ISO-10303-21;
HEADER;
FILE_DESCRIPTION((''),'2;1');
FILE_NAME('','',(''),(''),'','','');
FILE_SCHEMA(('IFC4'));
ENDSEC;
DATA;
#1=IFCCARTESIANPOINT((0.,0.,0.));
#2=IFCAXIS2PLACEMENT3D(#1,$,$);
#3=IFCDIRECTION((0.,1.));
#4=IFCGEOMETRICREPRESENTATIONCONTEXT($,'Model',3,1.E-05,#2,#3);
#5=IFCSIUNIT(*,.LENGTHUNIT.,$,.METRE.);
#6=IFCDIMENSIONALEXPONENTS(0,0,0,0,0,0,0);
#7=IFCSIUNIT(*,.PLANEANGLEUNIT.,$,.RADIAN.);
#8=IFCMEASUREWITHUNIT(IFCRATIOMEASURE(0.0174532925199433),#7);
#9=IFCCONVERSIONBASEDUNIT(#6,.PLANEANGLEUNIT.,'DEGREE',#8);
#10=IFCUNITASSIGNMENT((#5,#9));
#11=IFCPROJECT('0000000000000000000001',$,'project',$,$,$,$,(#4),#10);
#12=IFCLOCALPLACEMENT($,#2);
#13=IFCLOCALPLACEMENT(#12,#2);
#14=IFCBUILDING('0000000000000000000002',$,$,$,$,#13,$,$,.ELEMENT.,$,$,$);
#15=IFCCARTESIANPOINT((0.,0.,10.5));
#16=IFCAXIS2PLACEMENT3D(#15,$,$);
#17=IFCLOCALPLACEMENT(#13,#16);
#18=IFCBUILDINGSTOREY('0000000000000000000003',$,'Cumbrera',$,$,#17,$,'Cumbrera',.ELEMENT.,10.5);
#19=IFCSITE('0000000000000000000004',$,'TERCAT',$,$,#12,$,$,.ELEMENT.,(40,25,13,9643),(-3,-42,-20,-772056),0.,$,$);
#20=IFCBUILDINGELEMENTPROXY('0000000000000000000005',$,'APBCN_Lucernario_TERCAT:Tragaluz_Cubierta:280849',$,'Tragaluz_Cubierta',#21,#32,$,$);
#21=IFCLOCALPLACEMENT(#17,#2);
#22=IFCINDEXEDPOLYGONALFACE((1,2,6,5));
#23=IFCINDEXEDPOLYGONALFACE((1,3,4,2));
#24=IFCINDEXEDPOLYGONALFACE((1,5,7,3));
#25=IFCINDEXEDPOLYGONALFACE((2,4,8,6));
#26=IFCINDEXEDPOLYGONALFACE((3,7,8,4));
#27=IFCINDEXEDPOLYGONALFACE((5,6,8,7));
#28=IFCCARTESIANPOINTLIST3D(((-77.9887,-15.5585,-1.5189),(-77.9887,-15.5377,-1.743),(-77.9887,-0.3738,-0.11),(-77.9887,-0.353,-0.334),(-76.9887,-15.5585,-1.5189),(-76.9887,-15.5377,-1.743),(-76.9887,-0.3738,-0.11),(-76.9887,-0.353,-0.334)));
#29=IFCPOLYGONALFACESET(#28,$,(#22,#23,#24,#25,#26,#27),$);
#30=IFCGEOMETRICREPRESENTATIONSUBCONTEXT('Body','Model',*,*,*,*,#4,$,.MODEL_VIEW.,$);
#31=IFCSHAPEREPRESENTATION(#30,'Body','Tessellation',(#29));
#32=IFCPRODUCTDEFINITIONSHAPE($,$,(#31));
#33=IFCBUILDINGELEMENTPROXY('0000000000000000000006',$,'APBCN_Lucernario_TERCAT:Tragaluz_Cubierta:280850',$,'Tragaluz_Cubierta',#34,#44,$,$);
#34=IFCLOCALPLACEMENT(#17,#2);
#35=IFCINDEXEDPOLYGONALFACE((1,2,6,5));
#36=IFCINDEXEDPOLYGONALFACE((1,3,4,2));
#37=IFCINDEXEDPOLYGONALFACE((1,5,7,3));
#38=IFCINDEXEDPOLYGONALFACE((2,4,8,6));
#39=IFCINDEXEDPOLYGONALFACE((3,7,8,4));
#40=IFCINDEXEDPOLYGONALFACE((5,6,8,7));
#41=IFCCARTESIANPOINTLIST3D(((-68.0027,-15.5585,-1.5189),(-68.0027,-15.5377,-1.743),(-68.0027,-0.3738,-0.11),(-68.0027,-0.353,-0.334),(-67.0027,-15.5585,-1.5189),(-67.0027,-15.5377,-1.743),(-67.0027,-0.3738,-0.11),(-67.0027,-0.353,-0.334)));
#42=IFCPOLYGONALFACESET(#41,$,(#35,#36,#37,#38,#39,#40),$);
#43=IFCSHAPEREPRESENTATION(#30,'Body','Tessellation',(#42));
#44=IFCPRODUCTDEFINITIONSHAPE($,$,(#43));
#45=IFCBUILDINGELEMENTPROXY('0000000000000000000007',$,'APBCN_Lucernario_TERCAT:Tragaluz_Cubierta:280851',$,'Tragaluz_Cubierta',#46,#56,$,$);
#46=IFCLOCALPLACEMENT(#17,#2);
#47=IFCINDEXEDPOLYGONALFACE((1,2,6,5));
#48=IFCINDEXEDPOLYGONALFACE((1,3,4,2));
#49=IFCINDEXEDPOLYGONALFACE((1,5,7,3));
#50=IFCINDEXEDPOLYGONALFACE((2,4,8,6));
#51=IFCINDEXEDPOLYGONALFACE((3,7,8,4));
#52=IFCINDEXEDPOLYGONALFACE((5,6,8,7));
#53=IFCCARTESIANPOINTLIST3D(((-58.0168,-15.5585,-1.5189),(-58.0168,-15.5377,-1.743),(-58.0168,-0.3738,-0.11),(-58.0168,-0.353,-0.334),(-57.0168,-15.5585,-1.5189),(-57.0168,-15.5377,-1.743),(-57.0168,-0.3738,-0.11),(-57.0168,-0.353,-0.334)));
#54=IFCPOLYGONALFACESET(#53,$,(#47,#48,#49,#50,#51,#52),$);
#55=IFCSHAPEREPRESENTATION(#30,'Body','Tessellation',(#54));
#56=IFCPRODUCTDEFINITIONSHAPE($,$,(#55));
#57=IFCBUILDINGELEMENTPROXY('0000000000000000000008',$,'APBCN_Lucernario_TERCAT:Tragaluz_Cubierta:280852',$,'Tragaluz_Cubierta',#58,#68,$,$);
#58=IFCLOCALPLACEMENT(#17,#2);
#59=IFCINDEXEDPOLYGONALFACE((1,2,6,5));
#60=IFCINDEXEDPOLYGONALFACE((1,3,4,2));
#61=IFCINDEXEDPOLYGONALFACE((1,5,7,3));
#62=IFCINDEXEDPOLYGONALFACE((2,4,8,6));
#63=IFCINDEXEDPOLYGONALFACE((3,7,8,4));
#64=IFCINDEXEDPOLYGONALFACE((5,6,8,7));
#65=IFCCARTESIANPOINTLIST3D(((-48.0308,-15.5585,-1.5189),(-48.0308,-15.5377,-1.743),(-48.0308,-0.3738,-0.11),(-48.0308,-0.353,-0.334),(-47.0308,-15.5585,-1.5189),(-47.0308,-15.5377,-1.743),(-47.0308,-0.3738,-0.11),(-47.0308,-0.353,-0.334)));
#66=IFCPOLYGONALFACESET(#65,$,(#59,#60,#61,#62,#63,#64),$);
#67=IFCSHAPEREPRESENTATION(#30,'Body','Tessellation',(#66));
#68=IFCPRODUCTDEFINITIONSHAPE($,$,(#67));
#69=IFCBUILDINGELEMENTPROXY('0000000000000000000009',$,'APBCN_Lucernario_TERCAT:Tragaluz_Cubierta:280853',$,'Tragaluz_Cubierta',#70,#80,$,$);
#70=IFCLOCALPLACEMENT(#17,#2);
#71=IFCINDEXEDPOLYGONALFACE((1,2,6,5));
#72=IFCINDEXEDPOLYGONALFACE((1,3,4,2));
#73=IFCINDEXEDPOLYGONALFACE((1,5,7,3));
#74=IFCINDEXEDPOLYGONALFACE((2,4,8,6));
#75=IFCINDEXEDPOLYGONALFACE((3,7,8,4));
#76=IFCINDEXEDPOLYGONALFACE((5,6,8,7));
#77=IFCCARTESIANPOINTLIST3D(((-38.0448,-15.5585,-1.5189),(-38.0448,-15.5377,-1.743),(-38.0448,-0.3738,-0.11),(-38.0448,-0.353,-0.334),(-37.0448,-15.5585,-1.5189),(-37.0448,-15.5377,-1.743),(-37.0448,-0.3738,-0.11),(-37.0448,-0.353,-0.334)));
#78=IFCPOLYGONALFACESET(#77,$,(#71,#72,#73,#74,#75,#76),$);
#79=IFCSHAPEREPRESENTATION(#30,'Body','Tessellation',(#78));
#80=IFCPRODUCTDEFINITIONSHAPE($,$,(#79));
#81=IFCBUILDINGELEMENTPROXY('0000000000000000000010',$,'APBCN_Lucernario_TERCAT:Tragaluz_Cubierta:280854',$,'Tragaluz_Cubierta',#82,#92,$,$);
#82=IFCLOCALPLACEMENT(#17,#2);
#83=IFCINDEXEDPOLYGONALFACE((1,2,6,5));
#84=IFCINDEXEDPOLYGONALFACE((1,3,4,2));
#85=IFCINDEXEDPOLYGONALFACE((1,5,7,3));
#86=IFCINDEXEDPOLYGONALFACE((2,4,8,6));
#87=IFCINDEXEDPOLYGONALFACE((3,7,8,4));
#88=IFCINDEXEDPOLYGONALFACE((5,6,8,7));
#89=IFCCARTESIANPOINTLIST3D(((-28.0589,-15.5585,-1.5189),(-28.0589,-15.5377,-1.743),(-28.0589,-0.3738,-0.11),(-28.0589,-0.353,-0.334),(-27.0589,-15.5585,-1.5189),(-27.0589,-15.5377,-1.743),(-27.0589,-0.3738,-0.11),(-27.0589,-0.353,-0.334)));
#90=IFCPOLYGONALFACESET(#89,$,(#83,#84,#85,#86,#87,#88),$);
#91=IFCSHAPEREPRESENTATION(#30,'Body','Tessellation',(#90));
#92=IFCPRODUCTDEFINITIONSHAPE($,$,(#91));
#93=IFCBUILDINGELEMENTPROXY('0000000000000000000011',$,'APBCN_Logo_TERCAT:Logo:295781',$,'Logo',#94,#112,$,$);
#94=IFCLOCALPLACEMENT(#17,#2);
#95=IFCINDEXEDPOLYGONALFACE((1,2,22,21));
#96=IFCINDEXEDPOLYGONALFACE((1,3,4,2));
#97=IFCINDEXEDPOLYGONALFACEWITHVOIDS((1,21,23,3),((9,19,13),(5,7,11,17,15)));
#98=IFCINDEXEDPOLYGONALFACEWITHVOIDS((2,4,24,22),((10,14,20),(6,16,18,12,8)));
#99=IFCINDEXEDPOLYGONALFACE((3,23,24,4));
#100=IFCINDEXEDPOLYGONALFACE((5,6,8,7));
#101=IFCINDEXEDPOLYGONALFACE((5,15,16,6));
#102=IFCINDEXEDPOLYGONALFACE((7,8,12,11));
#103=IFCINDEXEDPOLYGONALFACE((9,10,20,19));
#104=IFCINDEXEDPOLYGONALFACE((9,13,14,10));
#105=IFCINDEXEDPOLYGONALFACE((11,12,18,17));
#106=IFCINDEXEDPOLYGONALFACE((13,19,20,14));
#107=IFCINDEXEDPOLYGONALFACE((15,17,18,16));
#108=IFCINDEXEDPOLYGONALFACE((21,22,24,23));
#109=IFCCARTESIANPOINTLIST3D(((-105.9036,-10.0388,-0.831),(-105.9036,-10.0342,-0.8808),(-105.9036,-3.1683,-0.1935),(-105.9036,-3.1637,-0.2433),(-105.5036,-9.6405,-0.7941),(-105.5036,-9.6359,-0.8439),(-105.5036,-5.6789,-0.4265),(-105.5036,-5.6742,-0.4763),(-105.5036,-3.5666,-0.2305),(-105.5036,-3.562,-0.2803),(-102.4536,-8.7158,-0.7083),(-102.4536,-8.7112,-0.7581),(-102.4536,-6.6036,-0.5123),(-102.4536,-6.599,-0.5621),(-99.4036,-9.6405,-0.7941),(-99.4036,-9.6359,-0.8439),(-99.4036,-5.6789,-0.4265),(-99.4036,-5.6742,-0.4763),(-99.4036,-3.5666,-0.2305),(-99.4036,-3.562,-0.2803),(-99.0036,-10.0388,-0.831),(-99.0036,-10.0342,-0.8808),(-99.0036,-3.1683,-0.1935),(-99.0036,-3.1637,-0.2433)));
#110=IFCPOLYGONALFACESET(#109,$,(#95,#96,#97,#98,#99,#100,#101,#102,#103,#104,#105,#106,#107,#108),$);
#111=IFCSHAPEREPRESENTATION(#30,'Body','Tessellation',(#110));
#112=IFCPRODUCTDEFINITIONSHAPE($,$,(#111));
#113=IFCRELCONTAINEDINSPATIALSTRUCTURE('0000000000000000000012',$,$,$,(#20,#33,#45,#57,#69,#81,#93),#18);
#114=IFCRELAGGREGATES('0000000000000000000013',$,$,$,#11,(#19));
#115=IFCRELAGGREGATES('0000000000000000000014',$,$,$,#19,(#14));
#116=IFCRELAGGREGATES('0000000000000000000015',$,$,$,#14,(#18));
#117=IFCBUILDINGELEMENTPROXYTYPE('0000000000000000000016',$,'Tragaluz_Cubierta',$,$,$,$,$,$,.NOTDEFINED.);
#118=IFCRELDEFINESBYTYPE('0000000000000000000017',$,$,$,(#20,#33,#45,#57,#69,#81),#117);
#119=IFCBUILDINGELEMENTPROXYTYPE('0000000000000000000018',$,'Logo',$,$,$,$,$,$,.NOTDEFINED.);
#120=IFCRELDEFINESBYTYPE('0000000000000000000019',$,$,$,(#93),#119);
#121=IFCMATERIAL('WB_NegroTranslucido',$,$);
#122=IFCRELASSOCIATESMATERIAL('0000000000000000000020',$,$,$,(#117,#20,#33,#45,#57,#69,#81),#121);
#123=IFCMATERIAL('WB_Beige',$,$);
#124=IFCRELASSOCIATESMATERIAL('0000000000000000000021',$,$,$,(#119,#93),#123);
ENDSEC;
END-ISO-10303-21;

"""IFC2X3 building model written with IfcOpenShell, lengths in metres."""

from ifc_helpers import new_model, entity, si_unit, converted_unit, direction, frame, origin, origin_2d_with_axis, place, context, subcontext, project, spatial, polyline, rectangle, outline, extrude, source, transform, mapped, material, type_object, type_shapes, element, save


model = new_model("IFC2X3")

# Units and contexts
model_context = context("Model", 3, precision=1e-05, world=origin(), true_north=direction((0.0, 1.0)))
body_context = subcontext(model_context, "Body", "Model", "MODEL_VIEW")
ifc_project = project(units=[si_unit("LENGTHUNIT", "METRE"), converted_unit("PLANEANGLEUNIT", "DEGREE", entity("IfcRatioMeasure", 0.0174532925199433), si_unit("PLANEANGLEUNIT", "RADIAN"), dimensions=[0, 0, 0, 0, 0, 0, 0])], contexts=[model_context])

# Site, building, storey
site_placement = place(None, origin())
site = spatial("IfcSite", under=ifc_project, at=site_placement, Name="TERCAT", CompositionType="ELEMENT", RefLatitude=(40, 25, 13, 9643), RefLongitude=(-3, -42, -20, -772056), RefElevation=0.0)
building_placement = place(site_placement, origin())
building = spatial("IfcBuilding", under=site, at=building_placement, CompositionType="ELEMENT")
storey_placement = place(building_placement, frame((0.0, 0.0, 10.5)))
storey = spatial("IfcBuildingStorey", under=building, at=storey_placement, Name="Cumbrera", LongName="Cumbrera", CompositionType="ELEMENT", Elevation=10.5)

# Building element proxies
ifc_material_1 = material(Name="WB_NegroTranslucido")
building_element_proxy_type_1 = type_object("IfcBuildingElementProxyType", Name="Tragaluz_Cubierta", PredefinedType="NOTDEFINED", material=ifc_material_1)
shared_shape_1 = source(origin(), body_context, "Body", "SweptSolid", [
    extrude(rectangle(XDim=15.25, YDim=1.0, at=origin_2d_with_axis()), frame((0.5, 7.625, 0.0), z_axis=(0.0, 0.0, 1.0), x_axis=(0.0, 1.0, 0.0)), (0.0, 0.0, 1.0), 0.225),
])
type_shapes(building_element_proxy_type_1, [shared_shape_1])
for number, where, z_axis, x_axis, name in (
    (1, (-76.9887, -0.353, -0.334), (0.0, -0.09239, 0.995723), (-1.0, 0.0, 0.0), "APBCN_Lucernario_TERCAT:Tragaluz_Cubierta:280849"),
    (2, (-67.0027, -0.353, -0.334), (0.0, -0.09239, 0.995723), (-1.0, 0.0, 0.0), "APBCN_Lucernario_TERCAT:Tragaluz_Cubierta:280850"),
    (3, (-57.0168, -0.353, -0.334), (0.0, -0.09239, 0.995723), (-1.0, 0.0, 0.0), "APBCN_Lucernario_TERCAT:Tragaluz_Cubierta:280851"),
    (4, (-47.0308, -0.353, -0.334), (0.0, -0.09239, 0.995723), (-1.0, 0.0, 0.0), "APBCN_Lucernario_TERCAT:Tragaluz_Cubierta:280852"),
    (5, (-37.0448, -0.353, -0.334), (0.0, -0.09239, 0.995723), (-1.0, 0.0, 0.0), "APBCN_Lucernario_TERCAT:Tragaluz_Cubierta:280853"),
    (6, (-27.0589, -0.353, -0.334), (0.0, -0.09239, 0.995723), (-1.0, 0.0, 0.0), "APBCN_Lucernario_TERCAT:Tragaluz_Cubierta:280854"),
):
    element("IfcBuildingElementProxy", number, at=place(storey_placement, frame(where, z_axis=z_axis, x_axis=x_axis)), inside=storey, type_object=building_element_proxy_type_1, material=ifc_material_1, Name=name, ObjectType="Tragaluz_Cubierta", context=body_context, shape_type="MappedRepresentation", body=[
        mapped(shared_shape_1, transform((0.0, 0.0, 0.0), scale=1.0)),
    ])
ifc_material_2 = material(Name="WB_Beige")
building_element_proxy_type_2 = type_object("IfcBuildingElementProxyType", Name="Logo", PredefinedType="NOTDEFINED", material=ifc_material_2)
shared_shape_2 = source(origin(), body_context, "Body", "SweptSolid", [
    extrude(outline(polyline([(-3.45, -3.45), (3.45, -3.45), (3.45, 3.45), (-3.45, 3.45), (-3.45, -3.45)]), holes=[polyline([(3.05, -0.9287), (0.0, 2.1213), (-3.05, -0.9287), (-3.05, 3.05), (3.05, 3.05), (3.05, -0.9287)]), polyline([(-3.05, -3.05), (0.0, 0.0), (3.05, -3.05), (-3.05, -3.05)])]), frame((0.0, 0.0, 0.0), z_axis=(0.0, 0.0, 1.0), x_axis=(-1.0, 0.0, 0.0)), (0.0, 0.0, 1.0), 0.05),
])
type_shapes(building_element_proxy_type_2, [shared_shape_2])
proxy_1_placement = place(storey_placement, frame((-102.4536, -6.599, -0.5621), z_axis=(0.0, -0.09239, 0.995723), x_axis=(1.0, 0.0, 0.0)))
element("IfcBuildingElementProxy", 7, at=proxy_1_placement, inside=storey, type_object=building_element_proxy_type_2, material=ifc_material_2, Name="APBCN_Logo_TERCAT:Logo:295781", ObjectType="Logo", context=body_context, shape_type="MappedRepresentation", body=[
    mapped(shared_shape_2, transform((0.0, 0.0, 0.0), scale=1.0)),
])

save(model, "model.ifc")
